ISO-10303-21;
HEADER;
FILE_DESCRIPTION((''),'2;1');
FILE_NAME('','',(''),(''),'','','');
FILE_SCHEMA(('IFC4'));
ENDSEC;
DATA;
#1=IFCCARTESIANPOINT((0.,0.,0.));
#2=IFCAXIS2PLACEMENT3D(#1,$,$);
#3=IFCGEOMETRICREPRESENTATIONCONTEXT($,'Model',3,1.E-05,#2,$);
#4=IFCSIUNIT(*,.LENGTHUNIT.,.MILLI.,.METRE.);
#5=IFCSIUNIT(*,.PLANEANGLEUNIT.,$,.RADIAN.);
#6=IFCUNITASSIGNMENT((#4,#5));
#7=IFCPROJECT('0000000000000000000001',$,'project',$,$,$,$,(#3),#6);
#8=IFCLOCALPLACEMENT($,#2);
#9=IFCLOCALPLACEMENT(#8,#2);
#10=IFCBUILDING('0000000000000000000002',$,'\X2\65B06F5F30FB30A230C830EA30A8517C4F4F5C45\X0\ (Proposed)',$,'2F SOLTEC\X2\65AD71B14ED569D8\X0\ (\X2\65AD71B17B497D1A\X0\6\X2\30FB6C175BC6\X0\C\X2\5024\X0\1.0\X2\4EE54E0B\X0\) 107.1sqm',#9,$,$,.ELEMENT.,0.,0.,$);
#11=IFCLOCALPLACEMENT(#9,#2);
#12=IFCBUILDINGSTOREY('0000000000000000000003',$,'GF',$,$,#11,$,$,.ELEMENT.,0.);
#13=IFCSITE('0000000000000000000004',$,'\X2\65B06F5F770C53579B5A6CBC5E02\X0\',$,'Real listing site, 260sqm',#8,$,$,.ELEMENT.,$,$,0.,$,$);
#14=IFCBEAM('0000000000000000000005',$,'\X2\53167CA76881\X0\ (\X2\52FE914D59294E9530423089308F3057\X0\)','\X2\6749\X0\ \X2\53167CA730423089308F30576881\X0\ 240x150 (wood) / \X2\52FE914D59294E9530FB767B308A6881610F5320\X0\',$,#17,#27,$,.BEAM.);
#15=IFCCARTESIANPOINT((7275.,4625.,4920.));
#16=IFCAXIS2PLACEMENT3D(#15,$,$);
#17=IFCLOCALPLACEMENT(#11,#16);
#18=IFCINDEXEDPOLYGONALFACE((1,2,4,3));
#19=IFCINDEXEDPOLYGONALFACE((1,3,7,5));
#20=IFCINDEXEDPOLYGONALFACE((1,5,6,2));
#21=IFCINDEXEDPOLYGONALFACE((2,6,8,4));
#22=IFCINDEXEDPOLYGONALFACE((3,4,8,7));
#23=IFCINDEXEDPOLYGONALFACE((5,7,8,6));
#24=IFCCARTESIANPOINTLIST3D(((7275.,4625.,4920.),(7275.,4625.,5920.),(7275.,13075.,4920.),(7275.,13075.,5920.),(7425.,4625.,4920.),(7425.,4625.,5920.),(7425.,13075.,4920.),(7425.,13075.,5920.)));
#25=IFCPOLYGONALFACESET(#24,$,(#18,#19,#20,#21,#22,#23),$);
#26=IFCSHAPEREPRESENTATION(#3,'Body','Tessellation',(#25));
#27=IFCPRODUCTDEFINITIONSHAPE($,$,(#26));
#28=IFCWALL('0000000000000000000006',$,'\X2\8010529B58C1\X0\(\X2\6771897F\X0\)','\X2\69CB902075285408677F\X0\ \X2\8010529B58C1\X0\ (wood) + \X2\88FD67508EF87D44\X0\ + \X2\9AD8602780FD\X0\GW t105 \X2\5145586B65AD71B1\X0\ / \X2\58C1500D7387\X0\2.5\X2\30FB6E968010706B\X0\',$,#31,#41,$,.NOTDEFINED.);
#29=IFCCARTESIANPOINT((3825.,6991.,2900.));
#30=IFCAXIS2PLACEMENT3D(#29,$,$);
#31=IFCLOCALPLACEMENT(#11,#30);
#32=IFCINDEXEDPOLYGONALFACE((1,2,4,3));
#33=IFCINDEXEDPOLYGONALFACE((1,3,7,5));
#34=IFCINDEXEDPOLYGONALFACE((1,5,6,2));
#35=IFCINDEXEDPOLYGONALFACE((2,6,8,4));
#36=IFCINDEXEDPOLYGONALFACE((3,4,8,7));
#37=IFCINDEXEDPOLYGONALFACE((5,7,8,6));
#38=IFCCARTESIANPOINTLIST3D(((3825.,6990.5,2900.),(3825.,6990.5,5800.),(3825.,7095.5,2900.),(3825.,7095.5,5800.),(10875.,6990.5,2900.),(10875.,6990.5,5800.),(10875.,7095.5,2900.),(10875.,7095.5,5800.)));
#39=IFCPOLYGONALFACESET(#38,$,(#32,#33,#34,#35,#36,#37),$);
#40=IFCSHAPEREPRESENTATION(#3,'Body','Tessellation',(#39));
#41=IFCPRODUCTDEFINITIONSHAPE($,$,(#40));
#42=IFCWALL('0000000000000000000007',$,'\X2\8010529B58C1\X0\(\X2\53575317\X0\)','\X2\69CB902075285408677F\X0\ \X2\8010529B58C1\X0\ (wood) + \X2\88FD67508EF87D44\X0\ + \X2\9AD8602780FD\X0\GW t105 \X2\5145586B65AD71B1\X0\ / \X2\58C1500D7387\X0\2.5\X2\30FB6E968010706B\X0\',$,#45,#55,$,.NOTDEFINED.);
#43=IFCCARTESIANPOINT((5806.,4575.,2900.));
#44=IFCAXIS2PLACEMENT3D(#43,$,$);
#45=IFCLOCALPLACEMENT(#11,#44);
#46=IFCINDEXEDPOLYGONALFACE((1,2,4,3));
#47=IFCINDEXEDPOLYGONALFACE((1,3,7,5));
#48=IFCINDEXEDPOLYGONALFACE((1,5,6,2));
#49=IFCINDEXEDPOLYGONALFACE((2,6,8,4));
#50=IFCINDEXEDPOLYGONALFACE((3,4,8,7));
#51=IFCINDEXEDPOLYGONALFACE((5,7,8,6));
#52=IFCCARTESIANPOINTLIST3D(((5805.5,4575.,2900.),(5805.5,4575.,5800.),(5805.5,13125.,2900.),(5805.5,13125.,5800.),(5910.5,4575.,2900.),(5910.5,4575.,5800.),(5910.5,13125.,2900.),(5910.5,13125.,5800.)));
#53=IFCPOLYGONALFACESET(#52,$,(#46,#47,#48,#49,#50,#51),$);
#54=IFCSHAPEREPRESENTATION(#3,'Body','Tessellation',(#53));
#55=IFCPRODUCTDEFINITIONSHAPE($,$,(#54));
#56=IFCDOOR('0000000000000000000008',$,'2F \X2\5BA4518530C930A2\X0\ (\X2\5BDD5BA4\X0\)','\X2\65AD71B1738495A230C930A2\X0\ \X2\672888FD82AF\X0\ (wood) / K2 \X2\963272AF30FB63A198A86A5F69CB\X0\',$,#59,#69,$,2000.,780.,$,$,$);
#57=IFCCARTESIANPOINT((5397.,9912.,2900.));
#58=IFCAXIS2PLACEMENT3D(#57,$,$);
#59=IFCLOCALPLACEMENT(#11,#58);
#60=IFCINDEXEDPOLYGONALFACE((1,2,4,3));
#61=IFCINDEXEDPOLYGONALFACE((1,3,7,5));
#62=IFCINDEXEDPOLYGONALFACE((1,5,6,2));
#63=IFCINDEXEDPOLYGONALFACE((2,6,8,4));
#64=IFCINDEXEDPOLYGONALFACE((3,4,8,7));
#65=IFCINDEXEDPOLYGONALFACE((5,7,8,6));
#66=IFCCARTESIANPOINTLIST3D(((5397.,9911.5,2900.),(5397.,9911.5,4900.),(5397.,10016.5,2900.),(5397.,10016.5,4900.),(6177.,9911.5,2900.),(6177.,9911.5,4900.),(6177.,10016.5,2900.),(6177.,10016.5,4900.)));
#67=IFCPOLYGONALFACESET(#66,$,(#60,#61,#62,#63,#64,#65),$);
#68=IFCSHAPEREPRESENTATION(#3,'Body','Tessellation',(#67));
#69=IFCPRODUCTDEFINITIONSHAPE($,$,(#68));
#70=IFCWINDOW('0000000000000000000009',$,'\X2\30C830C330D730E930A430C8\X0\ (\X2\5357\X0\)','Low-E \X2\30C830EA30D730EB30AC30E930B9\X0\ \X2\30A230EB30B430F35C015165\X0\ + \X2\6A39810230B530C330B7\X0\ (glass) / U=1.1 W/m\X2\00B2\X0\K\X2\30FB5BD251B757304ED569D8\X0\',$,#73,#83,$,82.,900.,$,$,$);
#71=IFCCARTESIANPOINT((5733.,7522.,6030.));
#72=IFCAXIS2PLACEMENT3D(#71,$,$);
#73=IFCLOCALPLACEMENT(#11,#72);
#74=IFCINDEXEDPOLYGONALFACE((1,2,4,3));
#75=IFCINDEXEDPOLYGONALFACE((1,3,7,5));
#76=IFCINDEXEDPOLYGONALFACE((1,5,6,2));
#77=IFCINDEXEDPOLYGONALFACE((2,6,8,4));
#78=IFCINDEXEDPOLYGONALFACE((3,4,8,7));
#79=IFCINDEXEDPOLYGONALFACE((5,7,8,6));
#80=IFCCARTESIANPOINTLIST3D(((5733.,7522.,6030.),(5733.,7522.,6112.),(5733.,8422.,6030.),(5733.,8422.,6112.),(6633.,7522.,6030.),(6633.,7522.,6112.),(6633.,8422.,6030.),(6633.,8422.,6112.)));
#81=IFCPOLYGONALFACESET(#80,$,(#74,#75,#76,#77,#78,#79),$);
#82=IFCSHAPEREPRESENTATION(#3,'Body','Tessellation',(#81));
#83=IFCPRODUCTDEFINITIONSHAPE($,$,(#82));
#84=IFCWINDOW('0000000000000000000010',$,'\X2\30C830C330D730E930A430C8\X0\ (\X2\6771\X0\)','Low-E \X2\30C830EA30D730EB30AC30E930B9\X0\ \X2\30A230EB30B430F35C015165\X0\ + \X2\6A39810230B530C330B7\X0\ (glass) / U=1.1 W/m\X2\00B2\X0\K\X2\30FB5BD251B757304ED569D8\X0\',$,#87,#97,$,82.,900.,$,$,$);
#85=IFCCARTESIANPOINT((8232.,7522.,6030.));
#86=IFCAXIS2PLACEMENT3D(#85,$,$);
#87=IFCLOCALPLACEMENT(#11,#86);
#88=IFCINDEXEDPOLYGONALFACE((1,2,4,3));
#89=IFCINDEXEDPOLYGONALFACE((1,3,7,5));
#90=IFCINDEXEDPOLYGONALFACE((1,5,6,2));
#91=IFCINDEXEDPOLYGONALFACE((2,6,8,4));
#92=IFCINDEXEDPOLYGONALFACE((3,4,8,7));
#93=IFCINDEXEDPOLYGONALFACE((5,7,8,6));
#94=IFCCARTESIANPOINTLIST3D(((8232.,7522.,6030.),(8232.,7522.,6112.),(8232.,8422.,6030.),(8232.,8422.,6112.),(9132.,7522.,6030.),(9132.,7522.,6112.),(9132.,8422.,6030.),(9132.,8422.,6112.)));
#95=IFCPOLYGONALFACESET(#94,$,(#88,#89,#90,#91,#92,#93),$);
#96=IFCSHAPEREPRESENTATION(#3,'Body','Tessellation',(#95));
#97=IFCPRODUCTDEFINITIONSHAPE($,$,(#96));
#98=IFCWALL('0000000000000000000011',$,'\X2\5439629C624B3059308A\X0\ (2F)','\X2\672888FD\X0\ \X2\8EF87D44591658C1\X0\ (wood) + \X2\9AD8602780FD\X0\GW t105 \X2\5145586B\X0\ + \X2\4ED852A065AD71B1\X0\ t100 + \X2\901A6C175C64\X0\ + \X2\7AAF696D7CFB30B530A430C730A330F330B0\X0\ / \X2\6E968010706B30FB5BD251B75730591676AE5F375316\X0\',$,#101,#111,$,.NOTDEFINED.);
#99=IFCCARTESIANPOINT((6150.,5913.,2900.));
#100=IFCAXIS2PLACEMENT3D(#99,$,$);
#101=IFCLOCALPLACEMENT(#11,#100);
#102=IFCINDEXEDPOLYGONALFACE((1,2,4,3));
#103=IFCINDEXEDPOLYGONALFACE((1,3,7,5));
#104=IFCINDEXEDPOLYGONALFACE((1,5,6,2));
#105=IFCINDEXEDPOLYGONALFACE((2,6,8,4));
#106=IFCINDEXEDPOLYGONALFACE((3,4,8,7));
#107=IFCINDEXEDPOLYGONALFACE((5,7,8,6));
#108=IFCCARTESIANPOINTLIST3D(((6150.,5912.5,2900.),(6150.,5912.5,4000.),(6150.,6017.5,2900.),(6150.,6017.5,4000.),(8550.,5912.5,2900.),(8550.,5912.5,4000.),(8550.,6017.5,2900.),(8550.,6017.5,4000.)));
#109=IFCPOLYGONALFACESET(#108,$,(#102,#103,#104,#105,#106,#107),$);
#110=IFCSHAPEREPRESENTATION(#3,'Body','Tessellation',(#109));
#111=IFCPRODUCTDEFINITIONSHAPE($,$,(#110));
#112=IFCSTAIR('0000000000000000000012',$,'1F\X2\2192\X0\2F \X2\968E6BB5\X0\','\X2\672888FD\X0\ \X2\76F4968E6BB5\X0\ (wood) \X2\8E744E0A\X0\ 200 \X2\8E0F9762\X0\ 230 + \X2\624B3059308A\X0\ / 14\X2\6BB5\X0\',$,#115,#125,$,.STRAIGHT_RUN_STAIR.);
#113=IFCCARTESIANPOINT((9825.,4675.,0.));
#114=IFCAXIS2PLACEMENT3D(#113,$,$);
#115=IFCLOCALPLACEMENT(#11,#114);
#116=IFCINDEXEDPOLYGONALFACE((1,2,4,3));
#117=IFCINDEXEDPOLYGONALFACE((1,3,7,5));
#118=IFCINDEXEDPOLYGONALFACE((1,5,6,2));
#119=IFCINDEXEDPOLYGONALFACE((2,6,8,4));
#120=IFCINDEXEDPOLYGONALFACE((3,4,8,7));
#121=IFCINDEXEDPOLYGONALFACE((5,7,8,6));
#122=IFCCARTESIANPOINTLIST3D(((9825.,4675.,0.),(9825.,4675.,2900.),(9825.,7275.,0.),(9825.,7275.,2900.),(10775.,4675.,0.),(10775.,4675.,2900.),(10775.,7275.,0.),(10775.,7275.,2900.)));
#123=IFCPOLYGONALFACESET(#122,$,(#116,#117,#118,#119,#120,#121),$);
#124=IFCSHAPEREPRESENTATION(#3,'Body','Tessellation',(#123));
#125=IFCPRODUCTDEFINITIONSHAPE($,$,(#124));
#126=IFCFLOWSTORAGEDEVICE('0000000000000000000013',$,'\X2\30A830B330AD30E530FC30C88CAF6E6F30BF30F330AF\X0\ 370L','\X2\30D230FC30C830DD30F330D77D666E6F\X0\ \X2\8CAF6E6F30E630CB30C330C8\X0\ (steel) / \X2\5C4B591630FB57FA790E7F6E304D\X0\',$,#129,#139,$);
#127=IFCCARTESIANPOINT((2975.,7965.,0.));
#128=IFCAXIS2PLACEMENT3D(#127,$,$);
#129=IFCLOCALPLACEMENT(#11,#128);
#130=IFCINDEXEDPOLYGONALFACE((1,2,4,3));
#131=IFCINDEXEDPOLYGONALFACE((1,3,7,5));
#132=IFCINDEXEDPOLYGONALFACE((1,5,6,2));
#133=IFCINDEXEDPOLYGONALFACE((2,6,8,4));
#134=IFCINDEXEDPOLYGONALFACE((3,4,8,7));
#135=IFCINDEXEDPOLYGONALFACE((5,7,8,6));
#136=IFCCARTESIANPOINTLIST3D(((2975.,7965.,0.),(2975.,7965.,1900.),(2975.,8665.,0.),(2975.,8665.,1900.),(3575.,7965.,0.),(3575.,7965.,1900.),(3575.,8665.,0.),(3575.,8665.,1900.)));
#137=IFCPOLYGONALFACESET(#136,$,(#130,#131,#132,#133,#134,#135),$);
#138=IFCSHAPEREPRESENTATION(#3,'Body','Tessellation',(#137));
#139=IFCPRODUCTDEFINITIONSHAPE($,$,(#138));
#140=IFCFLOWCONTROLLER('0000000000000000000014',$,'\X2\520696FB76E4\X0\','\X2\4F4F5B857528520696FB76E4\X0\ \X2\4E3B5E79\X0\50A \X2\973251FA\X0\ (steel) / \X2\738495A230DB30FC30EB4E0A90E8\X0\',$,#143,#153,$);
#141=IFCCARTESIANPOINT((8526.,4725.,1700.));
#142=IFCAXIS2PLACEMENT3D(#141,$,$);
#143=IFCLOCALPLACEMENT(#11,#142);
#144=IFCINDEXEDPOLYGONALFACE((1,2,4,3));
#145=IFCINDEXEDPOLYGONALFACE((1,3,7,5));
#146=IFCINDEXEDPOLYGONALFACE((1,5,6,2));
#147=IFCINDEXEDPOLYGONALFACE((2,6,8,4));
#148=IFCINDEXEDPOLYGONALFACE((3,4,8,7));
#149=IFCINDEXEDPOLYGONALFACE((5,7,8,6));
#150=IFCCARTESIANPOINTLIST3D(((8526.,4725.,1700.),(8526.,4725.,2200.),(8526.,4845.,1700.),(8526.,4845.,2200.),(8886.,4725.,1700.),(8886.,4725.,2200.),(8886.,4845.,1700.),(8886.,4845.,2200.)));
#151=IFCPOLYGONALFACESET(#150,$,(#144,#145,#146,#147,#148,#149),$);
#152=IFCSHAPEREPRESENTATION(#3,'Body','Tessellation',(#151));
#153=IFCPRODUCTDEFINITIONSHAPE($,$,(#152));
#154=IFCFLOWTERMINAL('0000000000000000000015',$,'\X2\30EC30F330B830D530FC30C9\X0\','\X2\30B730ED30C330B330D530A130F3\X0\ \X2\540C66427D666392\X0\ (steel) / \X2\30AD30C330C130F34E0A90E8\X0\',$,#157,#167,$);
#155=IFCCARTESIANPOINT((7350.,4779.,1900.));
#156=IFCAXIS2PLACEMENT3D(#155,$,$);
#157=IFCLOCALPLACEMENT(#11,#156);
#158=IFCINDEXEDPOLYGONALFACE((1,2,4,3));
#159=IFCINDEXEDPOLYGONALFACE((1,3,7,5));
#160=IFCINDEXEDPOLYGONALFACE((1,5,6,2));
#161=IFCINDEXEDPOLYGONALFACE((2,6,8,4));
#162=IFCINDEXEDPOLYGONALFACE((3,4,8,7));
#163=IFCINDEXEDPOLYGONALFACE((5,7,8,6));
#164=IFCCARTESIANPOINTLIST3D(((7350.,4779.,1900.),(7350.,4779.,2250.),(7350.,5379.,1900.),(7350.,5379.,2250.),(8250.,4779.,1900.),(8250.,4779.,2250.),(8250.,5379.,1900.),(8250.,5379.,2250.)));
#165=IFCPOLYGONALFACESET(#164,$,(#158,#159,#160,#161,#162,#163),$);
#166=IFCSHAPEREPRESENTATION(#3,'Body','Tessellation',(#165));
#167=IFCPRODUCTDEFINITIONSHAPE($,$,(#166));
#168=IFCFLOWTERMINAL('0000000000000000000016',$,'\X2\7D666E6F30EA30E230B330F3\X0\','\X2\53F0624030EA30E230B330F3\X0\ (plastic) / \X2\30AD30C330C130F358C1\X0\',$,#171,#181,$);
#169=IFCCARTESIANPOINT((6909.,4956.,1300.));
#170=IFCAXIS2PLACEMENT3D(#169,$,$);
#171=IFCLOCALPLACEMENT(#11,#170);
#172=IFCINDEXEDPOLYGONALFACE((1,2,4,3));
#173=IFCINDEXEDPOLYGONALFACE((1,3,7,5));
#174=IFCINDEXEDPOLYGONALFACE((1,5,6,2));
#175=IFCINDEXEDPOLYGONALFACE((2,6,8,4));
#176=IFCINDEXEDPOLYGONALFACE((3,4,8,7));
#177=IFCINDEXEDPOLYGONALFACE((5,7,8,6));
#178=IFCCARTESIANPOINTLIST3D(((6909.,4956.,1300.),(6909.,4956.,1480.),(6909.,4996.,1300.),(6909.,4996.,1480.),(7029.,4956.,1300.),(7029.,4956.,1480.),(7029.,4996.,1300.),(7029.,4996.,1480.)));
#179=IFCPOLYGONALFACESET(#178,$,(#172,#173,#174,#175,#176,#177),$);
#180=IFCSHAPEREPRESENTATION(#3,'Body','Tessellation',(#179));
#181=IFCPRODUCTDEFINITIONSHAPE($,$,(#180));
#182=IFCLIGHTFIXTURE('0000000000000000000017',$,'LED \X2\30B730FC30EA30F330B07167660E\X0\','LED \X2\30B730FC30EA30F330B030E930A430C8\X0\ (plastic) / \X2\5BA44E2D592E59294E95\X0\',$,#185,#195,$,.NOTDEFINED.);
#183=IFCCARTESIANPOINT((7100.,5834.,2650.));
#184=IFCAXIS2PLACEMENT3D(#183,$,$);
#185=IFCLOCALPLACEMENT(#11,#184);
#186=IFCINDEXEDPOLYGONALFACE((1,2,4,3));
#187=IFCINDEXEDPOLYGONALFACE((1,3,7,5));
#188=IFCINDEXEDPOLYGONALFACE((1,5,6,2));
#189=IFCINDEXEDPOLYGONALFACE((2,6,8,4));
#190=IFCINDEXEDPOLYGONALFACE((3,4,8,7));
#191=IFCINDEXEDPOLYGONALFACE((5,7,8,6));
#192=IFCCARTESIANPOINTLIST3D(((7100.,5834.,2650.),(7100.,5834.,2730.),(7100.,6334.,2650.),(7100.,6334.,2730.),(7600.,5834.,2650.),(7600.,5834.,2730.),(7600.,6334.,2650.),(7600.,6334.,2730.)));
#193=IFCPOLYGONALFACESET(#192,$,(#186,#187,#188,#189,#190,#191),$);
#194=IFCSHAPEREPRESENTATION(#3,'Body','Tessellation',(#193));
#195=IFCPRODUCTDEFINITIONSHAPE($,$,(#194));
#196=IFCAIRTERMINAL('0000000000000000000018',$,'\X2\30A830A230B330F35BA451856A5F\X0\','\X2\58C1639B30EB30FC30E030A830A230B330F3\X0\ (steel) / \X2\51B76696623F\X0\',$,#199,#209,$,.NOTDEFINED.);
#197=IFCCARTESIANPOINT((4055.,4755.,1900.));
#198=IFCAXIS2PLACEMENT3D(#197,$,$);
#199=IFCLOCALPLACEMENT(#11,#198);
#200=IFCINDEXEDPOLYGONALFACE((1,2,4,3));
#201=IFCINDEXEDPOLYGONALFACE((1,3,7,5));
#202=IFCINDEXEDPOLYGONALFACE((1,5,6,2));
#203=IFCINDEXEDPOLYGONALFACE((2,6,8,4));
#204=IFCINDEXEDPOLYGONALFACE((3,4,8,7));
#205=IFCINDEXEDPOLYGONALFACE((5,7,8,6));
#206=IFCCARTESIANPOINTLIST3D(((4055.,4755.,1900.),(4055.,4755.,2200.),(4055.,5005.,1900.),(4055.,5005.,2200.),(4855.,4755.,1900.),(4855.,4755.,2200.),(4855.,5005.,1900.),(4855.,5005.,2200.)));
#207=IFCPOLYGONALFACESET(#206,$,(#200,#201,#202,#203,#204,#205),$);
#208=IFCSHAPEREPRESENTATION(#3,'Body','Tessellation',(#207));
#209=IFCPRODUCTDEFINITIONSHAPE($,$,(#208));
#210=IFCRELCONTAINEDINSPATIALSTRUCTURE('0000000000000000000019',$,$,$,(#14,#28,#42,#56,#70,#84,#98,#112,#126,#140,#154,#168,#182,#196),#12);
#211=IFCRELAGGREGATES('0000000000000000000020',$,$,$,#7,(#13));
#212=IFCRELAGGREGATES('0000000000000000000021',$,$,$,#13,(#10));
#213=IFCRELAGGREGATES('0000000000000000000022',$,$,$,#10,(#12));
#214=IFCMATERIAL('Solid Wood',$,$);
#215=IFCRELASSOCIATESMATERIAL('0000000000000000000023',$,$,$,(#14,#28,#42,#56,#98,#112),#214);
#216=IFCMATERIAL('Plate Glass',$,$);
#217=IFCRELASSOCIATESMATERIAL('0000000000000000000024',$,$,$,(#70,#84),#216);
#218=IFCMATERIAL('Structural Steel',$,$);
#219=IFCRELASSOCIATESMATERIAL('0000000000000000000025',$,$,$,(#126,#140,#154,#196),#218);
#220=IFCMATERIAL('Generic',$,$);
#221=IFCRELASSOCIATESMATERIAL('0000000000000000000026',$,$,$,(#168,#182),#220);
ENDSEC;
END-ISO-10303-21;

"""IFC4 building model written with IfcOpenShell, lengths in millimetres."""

from ifc_helpers import new_model, si_unit, frame, frame_2d, origin, place, context, project, spatial, rectangle, extrude, material, element, fill, save


model = new_model("IFC4")

# Units and contexts
model_context = context("Model", 3, precision=1e-05, world=origin())
ifc_project = project(units=[si_unit("LENGTHUNIT", "METRE", prefix="MILLI"), si_unit("PLANEANGLEUNIT", "RADIAN")], contexts=[model_context])

# Site, building, storey
site_placement = place(None, origin())
site = spatial("IfcSite", under=ifc_project, at=site_placement, Name="新潟県南魚沼市", ObjectType="Real listing site, 260sqm", CompositionType="ELEMENT", RefElevation=0.0)
building_placement = place(site_placement, origin())
building = spatial("IfcBuilding", under=site, at=building_placement, Name="新潟・アトリエ兼住居 (Proposed)", ObjectType="2F SOLTEC断熱仕様 (断熱等級6・気密C値1.0以下) 107.1sqm", CompositionType="ELEMENT", ElevationOfRefHeight=0.0, ElevationOfTerrain=0.0)
storey_placement = place(building_placement, origin())
storey = spatial("IfcBuildingStorey", under=building, at=storey_placement, Name="GF", CompositionType="ELEMENT", Elevation=0.0)

# Shared definitions
ifc_material_1 = material(Name="Solid Wood")

# Beam
beam_placement = place(storey_placement, frame((7275.0, 4625.0, 4920.0)))
element("IfcBeam", 1, at=beam_placement, inside=storey, material=ifc_material_1, Name="化粧梁 (勾配天井あらわし)", Description="杉 化粧あらわし梁 240x150 (wood) / 勾配天井・登り梁意匠", PredefinedType="BEAM", context=model_context, shape_type="SweptSolid", body=[
    extrude(rectangle(XDim=150.0, YDim=8450.0, at=frame_2d((75.0, 4225.0))), frame((7275.0, 4625.0, 4920.0)), (0.0, 0.0, 1.0), 1000.0),
])

# Wall
wall_1_placement = place(storey_placement, frame((3825.0, 6991.0, 2900.0)))
element("IfcWall", 2, at=wall_1_placement, inside=storey, material=ifc_material_1, Name="耐力壁(東西)", Description="構造用合板 耐力壁 (wood) + 製材軸組 + 高性能GW t105 充填断熱 / 壁倍率2.5・準耐火", PredefinedType="NOTDEFINED", context=model_context, shape_type="SweptSolid", body=[
    extrude(rectangle(XDim=7050.0, YDim=105.0, at=frame_2d((3525.0, 52.0))), frame((3825.0, 6991.0, 2900.0)), (0.0, 0.0, 1.0), 2900.0),
])

# Wall, opening, door
wall_2_placement = place(storey_placement, frame((5806.0, 4575.0, 2900.0)))
wall_2 = element("IfcWall", 3, at=wall_2_placement, inside=storey, material=ifc_material_1, Name="耐力壁(南北)", Description="構造用合板 耐力壁 (wood) + 製材軸組 + 高性能GW t105 充填断熱 / 壁倍率2.5・準耐火", PredefinedType="NOTDEFINED", context=model_context, shape_type="SweptSolid", body=[
    extrude(rectangle(XDim=105.0, YDim=8550.0, at=frame_2d((52.0, 4275.0))), frame((5806.0, 4575.0, 2900.0)), (0.0, 0.0, 1.0), 2900.0),
])
opening_placement = place(storey_placement, frame((5397.0, 9912.0, 2900.0)))
opening = element("IfcOpeningElement", 4, at=opening_placement, cuts=wall_2, PredefinedType="NOTDEFINED", context=model_context, shape_type="SweptSolid", body=[
    extrude(rectangle(XDim=780.0, YDim=105.0, at=frame_2d((390.0, 52.0))), frame((5397.0, 9912.0, 2900.0)), (0.0, 0.0, 1.0), 2000.0),
])
door_placement = place(storey_placement, frame((5397.0, 9912.0, 2900.0)))
door = element("IfcDoor", 5, at=door_placement, inside=storey, material=ifc_material_1, Name="2F 室内ドア (寝室)", Description="断熱玄関ドア 木製芯 (wood) / K2 防犯・採風機構", OverallHeight=2000.0, OverallWidth=780.0, context=model_context, shape_type="SweptSolid", body=[
    extrude(rectangle(XDim=780.0, YDim=105.0, at=frame_2d((390.0, 52.0))), frame((5397.0, 9912.0, 2900.0)), (0.0, 0.0, 1.0), 2000.0),
])
fill(opening, door)

# Windows
ifc_material_2 = material(Name="Plate Glass")
window_1_placement = place(storey_placement, frame((5733.0, 7522.0, 6030.0)))
element("IfcWindow", 6, at=window_1_placement, inside=storey, material=ifc_material_2, Name="トップライト (南)", Description="Low-E トリプルガラス アルゴン封入 + 樹脂サッシ (glass) / U=1.1 W/m²K・寒冷地仕様", OverallHeight=82.0, OverallWidth=900.0, context=model_context, shape_type="SweptSolid", body=[
    extrude(rectangle(XDim=900.0, YDim=900.0, at=frame_2d((450.0, 450.0))), frame((5733.0, 7522.0, 6030.0)), (0.0, 0.0, 1.0), 82.0),
])
window_2_placement = place(storey_placement, frame((8232.0, 7522.0, 6030.0)))
element("IfcWindow", 7, at=window_2_placement, inside=storey, material=ifc_material_2, Name="トップライト (東)", Description="Low-E トリプルガラス アルゴン封入 + 樹脂サッシ (glass) / U=1.1 W/m²K・寒冷地仕様", OverallHeight=82.0, OverallWidth=900.0, context=model_context, shape_type="SweptSolid", body=[
    extrude(rectangle(XDim=900.0, YDim=900.0, at=frame_2d((450.0, 450.0))), frame((8232.0, 7522.0, 6030.0)), (0.0, 0.0, 1.0), 82.0),
])

# Wall
wall_3_placement = place(storey_placement, frame((6150.0, 5913.0, 2900.0)))
element("IfcWall", 8, at=wall_3_placement, inside=storey, material=ifc_material_1, Name="吹抜手すり (2F)", Description="木製 軸組外壁 (wood) + 高性能GW t105 充填 + 付加断熱 t100 + 通気層 + 窯業系サイディング / 準耐火・寒冷地外皮強化", PredefinedType="NOTDEFINED", context=model_context, shape_type="SweptSolid", body=[
    extrude(rectangle(XDim=2400.0, YDim=105.0, at=frame_2d((1200.0, 52.0))), frame((6150.0, 5913.0, 2900.0)), (0.0, 0.0, 1.0), 1100.0),
])

# Stair
stair_placement = place(storey_placement, frame((9825.0, 4675.0, 0.0)))
element("IfcStair", 9, at=stair_placement, inside=storey, material=ifc_material_1, Name="1F→2F 階段", Description="木製 直階段 (wood) 蹴上 200 踏面 230 + 手すり / 14段", PredefinedType="STRAIGHT_RUN_STAIR", context=model_context, shape_type="SweptSolid", body=[
    extrude(rectangle(XDim=950.0, YDim=2600.0, at=frame_2d((475.0, 1300.0))), frame((9825.0, 4675.0, 0.0)), (0.0, 0.0, 1.0), 2900.0),
])

# Flow storage device
ifc_material_3 = material(Name="Structural Steel")
flow_storage_device_placement = place(storey_placement, frame((2975.0, 7965.0, 0.0)))
element("IfcFlowStorageDevice", 10, at=flow_storage_device_placement, inside=storey, material=ifc_material_3, Name="エコキュート貯湯タンク 370L", Description="ヒートポンプ給湯 貯湯ユニット (steel) / 屋外・基礎置き", context=model_context, shape_type="SweptSolid", body=[
    extrude(rectangle(XDim=600.0, YDim=700.0, at=frame_2d((300.0, 350.0))), frame((2975.0, 7965.0, 0.0)), (0.0, 0.0, 1.0), 1900.0),
])

# Flow controller
flow_controller_placement = place(storey_placement, frame((8526.0, 4725.0, 1700.0)))
element("IfcFlowController", 11, at=flow_controller_placement, inside=storey, material=ifc_material_3, Name="分電盤", Description="住宅用分電盤 主幹50A 露出 (steel) / 玄関ホール上部", context=model_context, shape_type="SweptSolid", body=[
    extrude(rectangle(XDim=360.0, YDim=120.0, at=frame_2d((180.0, 60.0))), frame((8526.0, 4725.0, 1700.0)), (0.0, 0.0, 1.0), 500.0),
])

# Flow terminals
flow_terminal_1_placement = place(storey_placement, frame((7350.0, 4779.0, 1900.0)))
element("IfcFlowTerminal", 12, at=flow_terminal_1_placement, inside=storey, material=ifc_material_3, Name="レンジフード", Description="シロッコファン 同時給排 (steel) / キッチン上部", context=model_context, shape_type="SweptSolid", body=[
    extrude(rectangle(XDim=900.0, YDim=600.0, at=frame_2d((450.0, 300.0))), frame((7350.0, 4779.0, 1900.0)), (0.0, 0.0, 1.0), 350.0),
])
ifc_material_4 = material(Name="Generic")
flow_terminal_2_placement = place(storey_placement, frame((6909.0, 4956.0, 1300.0)))
element("IfcFlowTerminal", 13, at=flow_terminal_2_placement, inside=storey, material=ifc_material_4, Name="給湯リモコン", Description="台所リモコン (plastic) / キッチン壁", context=model_context, shape_type="SweptSolid", body=[
    extrude(rectangle(XDim=120.0, YDim=40.0, at=frame_2d((60.0, 20.0))), frame((6909.0, 4956.0, 1300.0)), (0.0, 0.0, 1.0), 180.0),
])

# Light fixture
light_fixture_1_placement = place(storey_placement, frame((7100.0, 5834.0, 2650.0)))
element("IfcLightFixture", 14, at=light_fixture_1_placement, inside=storey, material=ifc_material_4, Name="LED シーリング照明", Description="LED シーリングライト (plastic) / 室中央天井", PredefinedType="NOTDEFINED", context=model_context, shape_type="SweptSolid", body=[
    extrude(rectangle(XDim=500.0, YDim=500.0, at=frame_2d((250.0, 250.0))), frame((7100.0, 5834.0, 2650.0)), (0.0, 0.0, 1.0), 80.0),
])

# Air terminal
air_terminal_1_placement = place(storey_placement, frame((4055.0, 4755.0, 1900.0)))
element("IfcAirTerminal", 15, at=air_terminal_1_placement, inside=storey, material=ifc_material_3, Name="エアコン室内機", Description="壁掛ルームエアコン (steel) / 冷暖房", PredefinedType="NOTDEFINED", context=model_context, shape_type="SweptSolid", body=[
    extrude(rectangle(XDim=800.0, YDim=250.0, at=frame_2d((400.0, 125.0))), frame((4055.0, 4755.0, 1900.0)), (0.0, 0.0, 1.0), 300.0),
])

save(model, "model.ifc")
